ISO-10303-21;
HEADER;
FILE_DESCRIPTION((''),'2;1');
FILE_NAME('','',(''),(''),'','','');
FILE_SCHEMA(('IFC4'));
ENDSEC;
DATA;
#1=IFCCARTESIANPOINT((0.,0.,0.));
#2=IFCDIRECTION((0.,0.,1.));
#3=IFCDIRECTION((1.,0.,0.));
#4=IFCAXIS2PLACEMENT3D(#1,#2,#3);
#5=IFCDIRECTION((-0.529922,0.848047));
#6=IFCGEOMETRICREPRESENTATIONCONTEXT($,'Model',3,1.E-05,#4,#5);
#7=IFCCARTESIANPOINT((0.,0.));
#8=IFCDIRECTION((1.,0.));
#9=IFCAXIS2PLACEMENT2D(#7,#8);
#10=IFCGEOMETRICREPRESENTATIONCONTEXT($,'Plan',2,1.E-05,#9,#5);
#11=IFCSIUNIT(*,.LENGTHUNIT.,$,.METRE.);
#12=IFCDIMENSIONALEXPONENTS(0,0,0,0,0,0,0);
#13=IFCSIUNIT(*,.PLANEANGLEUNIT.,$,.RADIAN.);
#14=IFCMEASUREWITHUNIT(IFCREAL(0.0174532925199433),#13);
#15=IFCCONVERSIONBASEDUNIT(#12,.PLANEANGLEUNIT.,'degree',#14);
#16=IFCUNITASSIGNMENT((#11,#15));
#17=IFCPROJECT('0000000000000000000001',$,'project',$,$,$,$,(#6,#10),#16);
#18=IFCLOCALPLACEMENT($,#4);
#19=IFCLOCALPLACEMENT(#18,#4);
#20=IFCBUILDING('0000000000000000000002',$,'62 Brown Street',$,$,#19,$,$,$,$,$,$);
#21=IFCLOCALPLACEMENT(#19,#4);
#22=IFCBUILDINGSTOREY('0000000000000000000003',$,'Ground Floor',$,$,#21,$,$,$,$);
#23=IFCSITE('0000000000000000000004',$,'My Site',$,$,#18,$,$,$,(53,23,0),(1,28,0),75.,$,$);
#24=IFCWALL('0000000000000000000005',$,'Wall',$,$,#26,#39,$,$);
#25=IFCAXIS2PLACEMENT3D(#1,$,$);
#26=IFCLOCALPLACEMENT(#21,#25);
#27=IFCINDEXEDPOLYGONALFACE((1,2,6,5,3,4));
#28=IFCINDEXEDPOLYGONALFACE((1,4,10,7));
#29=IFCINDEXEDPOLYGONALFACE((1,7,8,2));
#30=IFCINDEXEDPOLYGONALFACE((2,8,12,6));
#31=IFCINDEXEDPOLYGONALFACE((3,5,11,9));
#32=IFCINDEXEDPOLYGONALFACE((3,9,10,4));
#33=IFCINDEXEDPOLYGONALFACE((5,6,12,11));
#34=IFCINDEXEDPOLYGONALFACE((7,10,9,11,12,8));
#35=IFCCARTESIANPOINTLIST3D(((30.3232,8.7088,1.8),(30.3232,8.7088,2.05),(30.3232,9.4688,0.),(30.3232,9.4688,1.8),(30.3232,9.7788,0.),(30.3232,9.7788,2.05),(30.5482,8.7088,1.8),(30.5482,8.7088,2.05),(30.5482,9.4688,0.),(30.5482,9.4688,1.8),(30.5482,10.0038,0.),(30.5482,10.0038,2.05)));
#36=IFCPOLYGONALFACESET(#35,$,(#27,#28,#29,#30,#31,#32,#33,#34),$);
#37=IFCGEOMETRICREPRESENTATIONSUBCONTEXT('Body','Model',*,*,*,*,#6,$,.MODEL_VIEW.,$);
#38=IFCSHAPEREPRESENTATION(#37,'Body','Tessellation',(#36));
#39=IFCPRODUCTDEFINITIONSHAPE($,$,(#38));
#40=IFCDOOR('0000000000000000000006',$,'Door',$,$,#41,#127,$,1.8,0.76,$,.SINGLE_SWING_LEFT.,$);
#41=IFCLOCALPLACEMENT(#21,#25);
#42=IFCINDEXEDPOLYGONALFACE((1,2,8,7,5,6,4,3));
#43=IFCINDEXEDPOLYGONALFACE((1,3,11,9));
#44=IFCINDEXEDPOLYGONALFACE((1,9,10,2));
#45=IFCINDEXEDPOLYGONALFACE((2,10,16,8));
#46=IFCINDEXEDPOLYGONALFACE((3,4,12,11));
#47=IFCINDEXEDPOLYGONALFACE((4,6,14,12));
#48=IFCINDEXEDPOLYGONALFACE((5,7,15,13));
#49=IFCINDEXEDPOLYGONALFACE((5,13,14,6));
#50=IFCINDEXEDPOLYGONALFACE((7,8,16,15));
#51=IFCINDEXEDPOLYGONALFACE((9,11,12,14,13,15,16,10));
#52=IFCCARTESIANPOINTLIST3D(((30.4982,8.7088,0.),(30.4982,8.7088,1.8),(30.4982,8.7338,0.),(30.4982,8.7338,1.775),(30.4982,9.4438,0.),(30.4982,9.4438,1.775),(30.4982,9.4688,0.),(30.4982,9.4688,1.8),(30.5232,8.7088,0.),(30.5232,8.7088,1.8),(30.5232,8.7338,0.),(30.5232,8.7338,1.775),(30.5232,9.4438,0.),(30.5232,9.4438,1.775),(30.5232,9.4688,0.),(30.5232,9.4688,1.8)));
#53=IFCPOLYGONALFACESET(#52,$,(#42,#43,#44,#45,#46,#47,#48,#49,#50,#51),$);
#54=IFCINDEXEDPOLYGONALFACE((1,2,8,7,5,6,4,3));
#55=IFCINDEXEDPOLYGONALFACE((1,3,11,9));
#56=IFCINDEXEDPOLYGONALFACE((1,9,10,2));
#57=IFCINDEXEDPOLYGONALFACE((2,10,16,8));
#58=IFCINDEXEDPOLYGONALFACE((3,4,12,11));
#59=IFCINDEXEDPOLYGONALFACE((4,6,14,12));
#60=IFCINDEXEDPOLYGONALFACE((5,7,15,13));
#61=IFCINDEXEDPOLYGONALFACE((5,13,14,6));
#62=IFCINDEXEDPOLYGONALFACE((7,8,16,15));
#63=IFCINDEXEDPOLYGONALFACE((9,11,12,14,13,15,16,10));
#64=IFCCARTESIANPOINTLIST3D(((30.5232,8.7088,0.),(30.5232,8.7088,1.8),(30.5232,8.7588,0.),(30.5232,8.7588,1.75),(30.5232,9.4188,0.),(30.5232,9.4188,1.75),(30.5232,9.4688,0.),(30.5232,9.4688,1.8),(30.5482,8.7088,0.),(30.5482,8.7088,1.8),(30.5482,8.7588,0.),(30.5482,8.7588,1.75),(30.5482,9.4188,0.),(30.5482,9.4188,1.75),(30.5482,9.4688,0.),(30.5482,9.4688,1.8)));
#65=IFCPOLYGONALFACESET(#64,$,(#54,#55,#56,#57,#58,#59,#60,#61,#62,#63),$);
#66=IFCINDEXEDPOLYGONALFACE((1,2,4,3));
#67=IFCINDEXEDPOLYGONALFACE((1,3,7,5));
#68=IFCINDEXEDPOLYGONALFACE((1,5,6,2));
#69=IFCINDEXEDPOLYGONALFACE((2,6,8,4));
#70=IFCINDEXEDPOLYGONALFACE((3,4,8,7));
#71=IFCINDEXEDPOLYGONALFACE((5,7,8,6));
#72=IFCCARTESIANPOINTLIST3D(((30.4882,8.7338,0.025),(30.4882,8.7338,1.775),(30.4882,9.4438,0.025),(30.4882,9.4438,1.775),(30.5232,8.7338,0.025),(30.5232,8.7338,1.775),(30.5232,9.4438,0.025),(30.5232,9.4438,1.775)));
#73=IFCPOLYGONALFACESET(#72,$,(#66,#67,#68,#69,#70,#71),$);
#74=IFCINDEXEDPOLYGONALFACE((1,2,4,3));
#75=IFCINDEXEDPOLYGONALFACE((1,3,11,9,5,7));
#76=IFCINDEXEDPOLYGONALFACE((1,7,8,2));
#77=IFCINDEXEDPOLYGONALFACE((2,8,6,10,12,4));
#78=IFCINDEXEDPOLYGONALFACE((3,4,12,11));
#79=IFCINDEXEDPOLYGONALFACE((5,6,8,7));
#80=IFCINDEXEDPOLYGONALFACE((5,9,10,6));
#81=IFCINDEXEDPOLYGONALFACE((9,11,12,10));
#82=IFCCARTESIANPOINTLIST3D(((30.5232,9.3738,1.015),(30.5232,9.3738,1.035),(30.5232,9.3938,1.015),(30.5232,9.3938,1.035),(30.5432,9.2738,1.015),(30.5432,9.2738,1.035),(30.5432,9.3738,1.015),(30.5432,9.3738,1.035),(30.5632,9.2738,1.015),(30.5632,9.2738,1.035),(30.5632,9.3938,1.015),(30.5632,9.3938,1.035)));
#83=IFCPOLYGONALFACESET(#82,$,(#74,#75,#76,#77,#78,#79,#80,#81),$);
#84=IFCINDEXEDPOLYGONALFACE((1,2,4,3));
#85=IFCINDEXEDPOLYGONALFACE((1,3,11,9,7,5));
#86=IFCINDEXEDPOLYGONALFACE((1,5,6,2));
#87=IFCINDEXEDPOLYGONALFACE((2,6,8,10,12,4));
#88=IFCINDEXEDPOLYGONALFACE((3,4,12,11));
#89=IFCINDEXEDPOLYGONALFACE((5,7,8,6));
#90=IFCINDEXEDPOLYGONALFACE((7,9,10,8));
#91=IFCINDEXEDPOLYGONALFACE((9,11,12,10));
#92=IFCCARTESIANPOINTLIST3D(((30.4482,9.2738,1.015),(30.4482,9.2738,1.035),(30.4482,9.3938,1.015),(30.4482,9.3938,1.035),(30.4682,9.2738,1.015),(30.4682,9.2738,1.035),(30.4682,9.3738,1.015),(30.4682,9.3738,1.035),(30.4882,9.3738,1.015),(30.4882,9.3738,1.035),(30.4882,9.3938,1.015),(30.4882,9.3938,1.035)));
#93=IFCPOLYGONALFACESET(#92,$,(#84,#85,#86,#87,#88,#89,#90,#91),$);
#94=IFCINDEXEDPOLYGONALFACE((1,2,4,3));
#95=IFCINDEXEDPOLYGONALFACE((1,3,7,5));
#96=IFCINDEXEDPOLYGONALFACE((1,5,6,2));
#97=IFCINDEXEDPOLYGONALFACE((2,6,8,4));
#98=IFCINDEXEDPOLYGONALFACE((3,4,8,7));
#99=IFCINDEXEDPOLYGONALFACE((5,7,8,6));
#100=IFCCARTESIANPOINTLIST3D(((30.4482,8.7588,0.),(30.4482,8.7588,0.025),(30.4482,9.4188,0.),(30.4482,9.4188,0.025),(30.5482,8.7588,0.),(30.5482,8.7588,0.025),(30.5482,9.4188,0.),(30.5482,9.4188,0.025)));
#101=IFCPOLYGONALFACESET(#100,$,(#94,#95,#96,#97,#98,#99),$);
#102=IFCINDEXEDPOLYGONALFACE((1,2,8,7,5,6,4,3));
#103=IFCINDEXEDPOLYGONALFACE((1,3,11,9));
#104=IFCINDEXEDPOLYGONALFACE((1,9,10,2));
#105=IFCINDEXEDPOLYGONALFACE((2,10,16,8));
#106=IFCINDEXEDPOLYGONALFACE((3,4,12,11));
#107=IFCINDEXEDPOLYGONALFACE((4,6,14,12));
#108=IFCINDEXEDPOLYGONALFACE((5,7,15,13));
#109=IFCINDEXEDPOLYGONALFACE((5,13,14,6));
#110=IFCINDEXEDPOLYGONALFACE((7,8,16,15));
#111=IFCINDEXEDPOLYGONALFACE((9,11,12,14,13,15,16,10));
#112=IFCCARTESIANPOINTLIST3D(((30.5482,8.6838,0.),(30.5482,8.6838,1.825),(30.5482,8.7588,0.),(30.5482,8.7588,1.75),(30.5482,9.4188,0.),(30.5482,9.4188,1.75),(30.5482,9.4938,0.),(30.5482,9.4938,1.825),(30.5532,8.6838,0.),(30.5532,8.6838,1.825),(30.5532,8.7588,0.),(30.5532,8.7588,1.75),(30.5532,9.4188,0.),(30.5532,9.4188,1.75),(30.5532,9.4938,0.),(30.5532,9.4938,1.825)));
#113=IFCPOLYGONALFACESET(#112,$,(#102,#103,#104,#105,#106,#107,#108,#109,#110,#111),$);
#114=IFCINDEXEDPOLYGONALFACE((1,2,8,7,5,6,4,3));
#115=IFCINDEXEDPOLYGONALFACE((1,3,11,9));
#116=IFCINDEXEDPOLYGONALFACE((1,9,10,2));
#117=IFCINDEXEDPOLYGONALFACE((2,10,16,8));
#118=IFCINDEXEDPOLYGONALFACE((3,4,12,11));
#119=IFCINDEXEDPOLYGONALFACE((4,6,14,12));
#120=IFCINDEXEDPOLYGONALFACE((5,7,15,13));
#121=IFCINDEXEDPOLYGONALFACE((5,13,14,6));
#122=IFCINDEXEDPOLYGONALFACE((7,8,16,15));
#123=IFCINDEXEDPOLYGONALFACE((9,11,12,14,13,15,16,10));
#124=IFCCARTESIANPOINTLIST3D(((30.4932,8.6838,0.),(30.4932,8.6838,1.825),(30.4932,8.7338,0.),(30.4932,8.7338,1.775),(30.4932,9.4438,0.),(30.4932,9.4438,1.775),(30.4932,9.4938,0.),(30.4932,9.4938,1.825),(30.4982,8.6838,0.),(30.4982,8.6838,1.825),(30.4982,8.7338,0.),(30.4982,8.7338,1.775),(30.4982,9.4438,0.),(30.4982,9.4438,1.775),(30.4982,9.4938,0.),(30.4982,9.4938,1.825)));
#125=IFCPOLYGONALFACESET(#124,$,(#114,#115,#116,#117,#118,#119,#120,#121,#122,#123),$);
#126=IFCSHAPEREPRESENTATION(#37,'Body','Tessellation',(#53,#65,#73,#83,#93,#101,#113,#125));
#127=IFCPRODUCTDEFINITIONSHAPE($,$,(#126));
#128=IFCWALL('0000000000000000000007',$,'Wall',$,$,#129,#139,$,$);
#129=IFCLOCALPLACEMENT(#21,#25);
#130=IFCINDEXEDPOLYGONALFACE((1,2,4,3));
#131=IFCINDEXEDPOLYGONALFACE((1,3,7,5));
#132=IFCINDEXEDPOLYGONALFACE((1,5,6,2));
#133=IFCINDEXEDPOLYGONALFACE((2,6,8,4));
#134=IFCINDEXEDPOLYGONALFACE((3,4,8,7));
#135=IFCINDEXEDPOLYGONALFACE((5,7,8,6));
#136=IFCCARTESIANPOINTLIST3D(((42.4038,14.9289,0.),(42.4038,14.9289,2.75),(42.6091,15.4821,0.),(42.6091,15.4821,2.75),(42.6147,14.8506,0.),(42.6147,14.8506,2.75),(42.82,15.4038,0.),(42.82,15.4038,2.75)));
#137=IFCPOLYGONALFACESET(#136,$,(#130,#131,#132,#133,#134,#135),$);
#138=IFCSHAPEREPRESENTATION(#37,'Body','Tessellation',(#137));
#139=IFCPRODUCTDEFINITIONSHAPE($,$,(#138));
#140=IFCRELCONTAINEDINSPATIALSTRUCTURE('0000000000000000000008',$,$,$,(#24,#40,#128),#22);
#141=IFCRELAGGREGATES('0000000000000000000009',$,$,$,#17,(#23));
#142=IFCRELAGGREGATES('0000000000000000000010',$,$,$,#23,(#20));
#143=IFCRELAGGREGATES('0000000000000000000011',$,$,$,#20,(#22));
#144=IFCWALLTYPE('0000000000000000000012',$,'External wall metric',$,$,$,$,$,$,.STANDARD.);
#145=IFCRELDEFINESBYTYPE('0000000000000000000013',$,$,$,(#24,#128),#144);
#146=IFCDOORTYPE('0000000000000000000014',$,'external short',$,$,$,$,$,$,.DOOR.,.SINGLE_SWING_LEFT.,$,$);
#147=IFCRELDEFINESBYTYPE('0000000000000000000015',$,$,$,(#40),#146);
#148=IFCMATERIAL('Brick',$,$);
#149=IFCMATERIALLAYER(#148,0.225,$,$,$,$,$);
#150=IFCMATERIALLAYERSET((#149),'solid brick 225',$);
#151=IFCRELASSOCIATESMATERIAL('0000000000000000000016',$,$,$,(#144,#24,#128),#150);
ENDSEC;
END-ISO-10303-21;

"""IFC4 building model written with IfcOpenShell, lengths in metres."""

from ifc_helpers import new_model, entity, si_unit, converted_unit, direction, frame, origin_with_axes, origin_2d_with_axis, place, context, subcontext, project, spatial, line, indexed_curve, outline, extrude, clip, halfspace, shape, source, transform, mapped, material, layer, layer_set, layer_usage, type_object, type_shapes, element, fill, save


model = new_model("IFC4")

# Units and contexts
model_context = context("Model", 3, precision=1e-05, world=origin_with_axes(), true_north=direction((-0.529922, 0.848047)))
plan_context = context("Plan", 2, precision=1e-05, world=origin_2d_with_axis(), true_north=direction((-0.529922, 0.848047)))
body_context_1 = subcontext(model_context, "Body", "Model", "MODEL_VIEW")
body_context_2 = subcontext(plan_context, "Body", "Plan", "PLAN_VIEW")
ifc_project = project(units=[si_unit("LENGTHUNIT", "METRE"), converted_unit("PLANEANGLEUNIT", "degree", entity("IfcReal", 0.0174532925199433), si_unit("PLANEANGLEUNIT", "RADIAN"), dimensions=[0, 0, 0, 0, 0, 0, 0])], contexts=[model_context, plan_context])

# Site, building, storey
site_placement = place(None, origin_with_axes())
site = spatial("IfcSite", under=ifc_project, at=site_placement, Name="My Site", RefLatitude=(53, 23, 0), RefLongitude=(1, 28, 0), RefElevation=75.0)
building_placement = place(site_placement, origin_with_axes())
building = spatial("IfcBuilding", under=site, at=building_placement, Name="62 Brown Street")
storey_placement = place(building_placement, origin_with_axes())
storey = spatial("IfcBuildingStorey", under=building, at=storey_placement, Name="Ground Floor")

# Shared definitions
ifc_material_1 = material(Name="Brick")
ifc_layer_1 = layer(ifc_material_1, 0.225)
ifc_layer_set_1 = layer_set([ifc_layer_1], Name="solid brick 225")
wall_type_1 = type_object("IfcWallType", Name="External wall metric", PredefinedType="STANDARD", material=ifc_layer_set_1)

# Wall, opening, door
ifc_layer_usage_1 = layer_usage(ifc_layer_set_1, "AXIS2", "POSITIVE", 0.0)
wall_1_placement = place(storey_placement, frame((30.5482, 8.7088, 0.0), z_axis=(0.0, 0.0, 1.0), x_axis=(0.0, 1.0, 0.0)))
wall_1 = element("IfcWall", 1, at=wall_1_placement, inside=storey, type_object=wall_type_1, material=ifc_layer_usage_1, Name="Wall", context=body_context_1, shape_type="Clipping", body=[
    clip(extrude(outline(indexed_curve([(0.0, 0.0), (0.0, 0.225), (1.295, 0.225), (1.295, 0.0), (0.0, 0.0)], self_intersect=False)), origin_with_axes(), (0.0, 0.0, 1.0), 2.05), halfspace(frame((1.295, 0.0, 0.0), z_axis=(0.450001, 0.450001, 0.0), x_axis=(-0.225, 0.225, 0.0)), False)),
])
shared_shape_1 = source(origin_with_axes(), body_context_1, "Body", "SweptSolid", [
    extrude(outline(indexed_curve([(0.0, 0.0), (0.76, 0.0), (0.76, 1.8), (0.0, 1.8)], segments=[line(1, 2, 3, 4, 1)])), frame((0.0, -0.1, 0.0), z_axis=(0.0, -1.0, 0.0), x_axis=(1.0, 0.0, 0.0)), (0.0, 0.0, -1.0), 0.425),
])
opening_1_placement = place(wall_1_placement, frame((0.0, 0.0, 0.0), z_axis=(0.0, 0.0, 1.0), x_axis=(1.0, 0.0, 0.0)))
opening_1 = element("IfcOpeningElement", 2, at=opening_1_placement, cuts=wall_1, PredefinedType="OPENING", context=body_context_1, shape_type="MappedRepresentation", body=[
    mapped(shared_shape_1, transform((0.0, 0.0, 0.0), x_axis=(1.0, 0.0, 0.0), y_axis=(0.0, 1.0, 0.0), z_axis=(0.0, 0.0, 1.0), scale=1.0)),
])
door_type_1 = type_object("IfcDoorType", Name="external short", OperationType="SINGLE_SWING_LEFT", PredefinedType="DOOR")
shared_shape_2 = source(origin_with_axes(), body_context_1, "Body", "SweptSolid", [
    extrude(outline(indexed_curve([(0.0, 0.0), (0.0, 1.8), (0.76, 1.8), (0.76, 0.0), (0.735, 0.0), (0.735, 1.775), (0.025, 1.775), (0.025, 0.0)], segments=[line(1, 2, 3, 4, 5, 6, 7, 8, 1)])), frame((0.0, 0.025, 0.0), z_axis=(0.0, -1.0, 0.0), x_axis=(1.0, 0.0, 0.0)), (0.0, 0.0, -1.0), 0.025),
    extrude(outline(indexed_curve([(0.0, 0.0), (0.0, 1.8), (0.76, 1.8), (0.76, 0.0), (0.71, 0.0), (0.71, 1.75), (0.05, 1.75), (0.05, 0.0)], segments=[line(1, 2, 3, 4, 5, 6, 7, 8, 1)])), frame((0.0, 0.0, 0.0), z_axis=(0.0, -1.0, 0.0), x_axis=(1.0, 0.0, 0.0)), (0.0, 0.0, -1.0), 0.025),
    extrude(outline(indexed_curve([(0.0, 0.0), (0.71, 0.0), (0.71, 0.035), (0.0, 0.035)], segments=[line(1, 2, 3, 4, 1)])), frame((0.025, 0.025, 0.025), z_axis=(0.0, 0.0, 1.0), x_axis=(1.0, 0.0, 0.0)), (0.0, 0.0, 1.0), 1.75),
    extrude(outline(indexed_curve([(0.0, 0.0), (0.0, -0.04), (-0.12, -0.04), (-0.12, -0.02), (-0.02, -0.02), (-0.02, 0.0)], segments=[line(1, 2, 3, 4, 5, 6, 1)])), frame((0.685, 0.025, 1.015), z_axis=(0.0, 0.0, 1.0), x_axis=(1.0, 0.0, 0.0)), (0.0, 0.0, 1.0), 0.02),
    extrude(outline(indexed_curve([(0.0, 0.0), (0.0, 0.04), (-0.12, 0.04), (-0.12, 0.02), (-0.02, 0.02), (-0.02, 0.0)], segments=[line(1, 2, 3, 4, 5, 6, 1)])), frame((0.685, 0.06, 1.015), z_axis=(0.0, 0.0, 1.0), x_axis=(1.0, 0.0, 0.0)), (0.0, 0.0, 1.0), 0.02),
    extrude(outline(indexed_curve([(0.0, 0.0), (0.66, 0.0), (0.66, 0.1), (0.0, 0.1)], segments=[line(1, 2, 3, 4, 1)])), frame((0.05, 0.0, 0.0), z_axis=(0.0, 0.0, 1.0), x_axis=(1.0, 0.0, 0.0)), (0.0, 0.0, 1.0), 0.025),
    extrude(outline(indexed_curve([(0.0, 0.0), (0.0, 1.825), (0.81, 1.825), (0.81, 0.0), (0.735, 0.0), (0.735, 1.75), (0.075, 1.75), (0.075, 0.0)], segments=[line(1, 2, 3, 4, 5, 6, 7, 8, 1)])), frame((-0.025, -0.005, 0.0), z_axis=(0.0, -1.0, 0.0), x_axis=(1.0, 0.0, 0.0)), (0.0, 0.0, -1.0), 0.005),
    extrude(outline(indexed_curve([(0.0, 0.0), (0.0, 1.825), (0.81, 1.825), (0.81, 0.0), (0.76, 0.0), (0.76, 1.775), (0.05, 1.775), (0.05, 0.0)], segments=[line(1, 2, 3, 4, 5, 6, 7, 8, 1)])), frame((-0.025, 0.05, 0.0), z_axis=(0.0, -1.0, 0.0), x_axis=(1.0, 0.0, 0.0)), (0.0, 0.0, -1.0), 0.005),
])
shared_shape_3 = source(origin_with_axes(), body_context_2, "Body", "Curve2D", [
    entity("IfcIndexedPolyCurve", entity("IfcCartesianPointList2D", [[0.0, 0.0], [0.0, 0.05], [0.025, 0.05], [0.025, 0.025], [0.05, 0.025], [0.05, 0.0]]), [entity("IfcLineIndex", [1, 2, 3, 4, 5, 6, 1])]),
    entity("IfcIndexedPolyCurve", entity("IfcCartesianPointList2D", [[0.76, 0.0], [0.76, 0.05], [0.735, 0.05], [0.735, 0.025], [0.71, 0.025], [0.71, 0.0]]), [entity("IfcLineIndex", [1, 2, 3, 4, 5, 6, 1])]),
    entity("IfcTrimmedCurve", entity("IfcEllipse", entity("IfcAxis2Placement2D", entity("IfcCartesianPoint", [0.06, 0.05]), entity("IfcDirection", [1.0, 0.0])), 0.675, 0.71), [entity("IfcCartesianPoint", [0.735, 0.05])], [entity("IfcCartesianPoint", [0.06, 0.76])], True, "CARTESIAN"),
    entity("IfcIndexedPolyCurve", entity("IfcCartesianPointList2D", [[0.025, 0.05], [0.06, 0.05], [0.06, 0.76], [0.025, 0.76]]), [entity("IfcLineIndex", [1, 2, 3, 4, 1])]),
])
type_shapes(door_type_1, [shared_shape_2, shared_shape_3])
door_1_placement = place(opening_1_placement, frame((0.0, 0.0, 0.0), z_axis=(0.0, 0.0, 1.0), x_axis=(1.0, 0.0, 0.0)))
door_1 = element("IfcDoor", 3, at=door_1_placement, inside=storey, type_object=door_type_1, Name="Door", OperationType="SINGLE_SWING_LEFT", OverallHeight=1.8, OverallWidth=0.76, shapes=[
    shape(body_context_1, "Body", "MappedRepresentation", [mapped(shared_shape_2, transform((0.0, 0.0, 0.0), x_axis=(1.0, 0.0, 0.0), y_axis=(0.0, 1.0, 0.0), z_axis=(0.0, 0.0, 1.0), scale=1.0))]),
    shape(body_context_2, "Body", "MappedRepresentation", [mapped(shared_shape_3, transform((0.0, 0.0, 0.0), x_axis=(1.0, 0.0, 0.0), y_axis=(0.0, 1.0, 0.0), z_axis=(0.0, 0.0, 1.0), scale=1.0))]),
])
fill(opening_1, door_1)

# Wall
ifc_layer_usage_2 = layer_usage(ifc_layer_set_1, "AXIS2", "POSITIVE", 0.0)
wall_2_placement = place(storey_placement, frame((42.6147, 14.8506, 0.0), z_axis=(0.0, 0.0, 1.0), x_axis=(0.347944, 0.937515, 0.0)))
element("IfcWall", 4, at=wall_2_placement, inside=storey, type_object=wall_type_1, material=ifc_layer_usage_2, Name="Wall", context=body_context_1, shape_type="SweptSolid", body=[
    extrude(outline(indexed_curve([(0.0, 0.0), (0.0, 0.225), (0.5901, 0.225), (0.5901, 0.0), (0.0, 0.0)], self_intersect=False)), origin_with_axes(), (0.0, 0.0, 1.0), 2.75),
])

save(model, "model.ifc")
